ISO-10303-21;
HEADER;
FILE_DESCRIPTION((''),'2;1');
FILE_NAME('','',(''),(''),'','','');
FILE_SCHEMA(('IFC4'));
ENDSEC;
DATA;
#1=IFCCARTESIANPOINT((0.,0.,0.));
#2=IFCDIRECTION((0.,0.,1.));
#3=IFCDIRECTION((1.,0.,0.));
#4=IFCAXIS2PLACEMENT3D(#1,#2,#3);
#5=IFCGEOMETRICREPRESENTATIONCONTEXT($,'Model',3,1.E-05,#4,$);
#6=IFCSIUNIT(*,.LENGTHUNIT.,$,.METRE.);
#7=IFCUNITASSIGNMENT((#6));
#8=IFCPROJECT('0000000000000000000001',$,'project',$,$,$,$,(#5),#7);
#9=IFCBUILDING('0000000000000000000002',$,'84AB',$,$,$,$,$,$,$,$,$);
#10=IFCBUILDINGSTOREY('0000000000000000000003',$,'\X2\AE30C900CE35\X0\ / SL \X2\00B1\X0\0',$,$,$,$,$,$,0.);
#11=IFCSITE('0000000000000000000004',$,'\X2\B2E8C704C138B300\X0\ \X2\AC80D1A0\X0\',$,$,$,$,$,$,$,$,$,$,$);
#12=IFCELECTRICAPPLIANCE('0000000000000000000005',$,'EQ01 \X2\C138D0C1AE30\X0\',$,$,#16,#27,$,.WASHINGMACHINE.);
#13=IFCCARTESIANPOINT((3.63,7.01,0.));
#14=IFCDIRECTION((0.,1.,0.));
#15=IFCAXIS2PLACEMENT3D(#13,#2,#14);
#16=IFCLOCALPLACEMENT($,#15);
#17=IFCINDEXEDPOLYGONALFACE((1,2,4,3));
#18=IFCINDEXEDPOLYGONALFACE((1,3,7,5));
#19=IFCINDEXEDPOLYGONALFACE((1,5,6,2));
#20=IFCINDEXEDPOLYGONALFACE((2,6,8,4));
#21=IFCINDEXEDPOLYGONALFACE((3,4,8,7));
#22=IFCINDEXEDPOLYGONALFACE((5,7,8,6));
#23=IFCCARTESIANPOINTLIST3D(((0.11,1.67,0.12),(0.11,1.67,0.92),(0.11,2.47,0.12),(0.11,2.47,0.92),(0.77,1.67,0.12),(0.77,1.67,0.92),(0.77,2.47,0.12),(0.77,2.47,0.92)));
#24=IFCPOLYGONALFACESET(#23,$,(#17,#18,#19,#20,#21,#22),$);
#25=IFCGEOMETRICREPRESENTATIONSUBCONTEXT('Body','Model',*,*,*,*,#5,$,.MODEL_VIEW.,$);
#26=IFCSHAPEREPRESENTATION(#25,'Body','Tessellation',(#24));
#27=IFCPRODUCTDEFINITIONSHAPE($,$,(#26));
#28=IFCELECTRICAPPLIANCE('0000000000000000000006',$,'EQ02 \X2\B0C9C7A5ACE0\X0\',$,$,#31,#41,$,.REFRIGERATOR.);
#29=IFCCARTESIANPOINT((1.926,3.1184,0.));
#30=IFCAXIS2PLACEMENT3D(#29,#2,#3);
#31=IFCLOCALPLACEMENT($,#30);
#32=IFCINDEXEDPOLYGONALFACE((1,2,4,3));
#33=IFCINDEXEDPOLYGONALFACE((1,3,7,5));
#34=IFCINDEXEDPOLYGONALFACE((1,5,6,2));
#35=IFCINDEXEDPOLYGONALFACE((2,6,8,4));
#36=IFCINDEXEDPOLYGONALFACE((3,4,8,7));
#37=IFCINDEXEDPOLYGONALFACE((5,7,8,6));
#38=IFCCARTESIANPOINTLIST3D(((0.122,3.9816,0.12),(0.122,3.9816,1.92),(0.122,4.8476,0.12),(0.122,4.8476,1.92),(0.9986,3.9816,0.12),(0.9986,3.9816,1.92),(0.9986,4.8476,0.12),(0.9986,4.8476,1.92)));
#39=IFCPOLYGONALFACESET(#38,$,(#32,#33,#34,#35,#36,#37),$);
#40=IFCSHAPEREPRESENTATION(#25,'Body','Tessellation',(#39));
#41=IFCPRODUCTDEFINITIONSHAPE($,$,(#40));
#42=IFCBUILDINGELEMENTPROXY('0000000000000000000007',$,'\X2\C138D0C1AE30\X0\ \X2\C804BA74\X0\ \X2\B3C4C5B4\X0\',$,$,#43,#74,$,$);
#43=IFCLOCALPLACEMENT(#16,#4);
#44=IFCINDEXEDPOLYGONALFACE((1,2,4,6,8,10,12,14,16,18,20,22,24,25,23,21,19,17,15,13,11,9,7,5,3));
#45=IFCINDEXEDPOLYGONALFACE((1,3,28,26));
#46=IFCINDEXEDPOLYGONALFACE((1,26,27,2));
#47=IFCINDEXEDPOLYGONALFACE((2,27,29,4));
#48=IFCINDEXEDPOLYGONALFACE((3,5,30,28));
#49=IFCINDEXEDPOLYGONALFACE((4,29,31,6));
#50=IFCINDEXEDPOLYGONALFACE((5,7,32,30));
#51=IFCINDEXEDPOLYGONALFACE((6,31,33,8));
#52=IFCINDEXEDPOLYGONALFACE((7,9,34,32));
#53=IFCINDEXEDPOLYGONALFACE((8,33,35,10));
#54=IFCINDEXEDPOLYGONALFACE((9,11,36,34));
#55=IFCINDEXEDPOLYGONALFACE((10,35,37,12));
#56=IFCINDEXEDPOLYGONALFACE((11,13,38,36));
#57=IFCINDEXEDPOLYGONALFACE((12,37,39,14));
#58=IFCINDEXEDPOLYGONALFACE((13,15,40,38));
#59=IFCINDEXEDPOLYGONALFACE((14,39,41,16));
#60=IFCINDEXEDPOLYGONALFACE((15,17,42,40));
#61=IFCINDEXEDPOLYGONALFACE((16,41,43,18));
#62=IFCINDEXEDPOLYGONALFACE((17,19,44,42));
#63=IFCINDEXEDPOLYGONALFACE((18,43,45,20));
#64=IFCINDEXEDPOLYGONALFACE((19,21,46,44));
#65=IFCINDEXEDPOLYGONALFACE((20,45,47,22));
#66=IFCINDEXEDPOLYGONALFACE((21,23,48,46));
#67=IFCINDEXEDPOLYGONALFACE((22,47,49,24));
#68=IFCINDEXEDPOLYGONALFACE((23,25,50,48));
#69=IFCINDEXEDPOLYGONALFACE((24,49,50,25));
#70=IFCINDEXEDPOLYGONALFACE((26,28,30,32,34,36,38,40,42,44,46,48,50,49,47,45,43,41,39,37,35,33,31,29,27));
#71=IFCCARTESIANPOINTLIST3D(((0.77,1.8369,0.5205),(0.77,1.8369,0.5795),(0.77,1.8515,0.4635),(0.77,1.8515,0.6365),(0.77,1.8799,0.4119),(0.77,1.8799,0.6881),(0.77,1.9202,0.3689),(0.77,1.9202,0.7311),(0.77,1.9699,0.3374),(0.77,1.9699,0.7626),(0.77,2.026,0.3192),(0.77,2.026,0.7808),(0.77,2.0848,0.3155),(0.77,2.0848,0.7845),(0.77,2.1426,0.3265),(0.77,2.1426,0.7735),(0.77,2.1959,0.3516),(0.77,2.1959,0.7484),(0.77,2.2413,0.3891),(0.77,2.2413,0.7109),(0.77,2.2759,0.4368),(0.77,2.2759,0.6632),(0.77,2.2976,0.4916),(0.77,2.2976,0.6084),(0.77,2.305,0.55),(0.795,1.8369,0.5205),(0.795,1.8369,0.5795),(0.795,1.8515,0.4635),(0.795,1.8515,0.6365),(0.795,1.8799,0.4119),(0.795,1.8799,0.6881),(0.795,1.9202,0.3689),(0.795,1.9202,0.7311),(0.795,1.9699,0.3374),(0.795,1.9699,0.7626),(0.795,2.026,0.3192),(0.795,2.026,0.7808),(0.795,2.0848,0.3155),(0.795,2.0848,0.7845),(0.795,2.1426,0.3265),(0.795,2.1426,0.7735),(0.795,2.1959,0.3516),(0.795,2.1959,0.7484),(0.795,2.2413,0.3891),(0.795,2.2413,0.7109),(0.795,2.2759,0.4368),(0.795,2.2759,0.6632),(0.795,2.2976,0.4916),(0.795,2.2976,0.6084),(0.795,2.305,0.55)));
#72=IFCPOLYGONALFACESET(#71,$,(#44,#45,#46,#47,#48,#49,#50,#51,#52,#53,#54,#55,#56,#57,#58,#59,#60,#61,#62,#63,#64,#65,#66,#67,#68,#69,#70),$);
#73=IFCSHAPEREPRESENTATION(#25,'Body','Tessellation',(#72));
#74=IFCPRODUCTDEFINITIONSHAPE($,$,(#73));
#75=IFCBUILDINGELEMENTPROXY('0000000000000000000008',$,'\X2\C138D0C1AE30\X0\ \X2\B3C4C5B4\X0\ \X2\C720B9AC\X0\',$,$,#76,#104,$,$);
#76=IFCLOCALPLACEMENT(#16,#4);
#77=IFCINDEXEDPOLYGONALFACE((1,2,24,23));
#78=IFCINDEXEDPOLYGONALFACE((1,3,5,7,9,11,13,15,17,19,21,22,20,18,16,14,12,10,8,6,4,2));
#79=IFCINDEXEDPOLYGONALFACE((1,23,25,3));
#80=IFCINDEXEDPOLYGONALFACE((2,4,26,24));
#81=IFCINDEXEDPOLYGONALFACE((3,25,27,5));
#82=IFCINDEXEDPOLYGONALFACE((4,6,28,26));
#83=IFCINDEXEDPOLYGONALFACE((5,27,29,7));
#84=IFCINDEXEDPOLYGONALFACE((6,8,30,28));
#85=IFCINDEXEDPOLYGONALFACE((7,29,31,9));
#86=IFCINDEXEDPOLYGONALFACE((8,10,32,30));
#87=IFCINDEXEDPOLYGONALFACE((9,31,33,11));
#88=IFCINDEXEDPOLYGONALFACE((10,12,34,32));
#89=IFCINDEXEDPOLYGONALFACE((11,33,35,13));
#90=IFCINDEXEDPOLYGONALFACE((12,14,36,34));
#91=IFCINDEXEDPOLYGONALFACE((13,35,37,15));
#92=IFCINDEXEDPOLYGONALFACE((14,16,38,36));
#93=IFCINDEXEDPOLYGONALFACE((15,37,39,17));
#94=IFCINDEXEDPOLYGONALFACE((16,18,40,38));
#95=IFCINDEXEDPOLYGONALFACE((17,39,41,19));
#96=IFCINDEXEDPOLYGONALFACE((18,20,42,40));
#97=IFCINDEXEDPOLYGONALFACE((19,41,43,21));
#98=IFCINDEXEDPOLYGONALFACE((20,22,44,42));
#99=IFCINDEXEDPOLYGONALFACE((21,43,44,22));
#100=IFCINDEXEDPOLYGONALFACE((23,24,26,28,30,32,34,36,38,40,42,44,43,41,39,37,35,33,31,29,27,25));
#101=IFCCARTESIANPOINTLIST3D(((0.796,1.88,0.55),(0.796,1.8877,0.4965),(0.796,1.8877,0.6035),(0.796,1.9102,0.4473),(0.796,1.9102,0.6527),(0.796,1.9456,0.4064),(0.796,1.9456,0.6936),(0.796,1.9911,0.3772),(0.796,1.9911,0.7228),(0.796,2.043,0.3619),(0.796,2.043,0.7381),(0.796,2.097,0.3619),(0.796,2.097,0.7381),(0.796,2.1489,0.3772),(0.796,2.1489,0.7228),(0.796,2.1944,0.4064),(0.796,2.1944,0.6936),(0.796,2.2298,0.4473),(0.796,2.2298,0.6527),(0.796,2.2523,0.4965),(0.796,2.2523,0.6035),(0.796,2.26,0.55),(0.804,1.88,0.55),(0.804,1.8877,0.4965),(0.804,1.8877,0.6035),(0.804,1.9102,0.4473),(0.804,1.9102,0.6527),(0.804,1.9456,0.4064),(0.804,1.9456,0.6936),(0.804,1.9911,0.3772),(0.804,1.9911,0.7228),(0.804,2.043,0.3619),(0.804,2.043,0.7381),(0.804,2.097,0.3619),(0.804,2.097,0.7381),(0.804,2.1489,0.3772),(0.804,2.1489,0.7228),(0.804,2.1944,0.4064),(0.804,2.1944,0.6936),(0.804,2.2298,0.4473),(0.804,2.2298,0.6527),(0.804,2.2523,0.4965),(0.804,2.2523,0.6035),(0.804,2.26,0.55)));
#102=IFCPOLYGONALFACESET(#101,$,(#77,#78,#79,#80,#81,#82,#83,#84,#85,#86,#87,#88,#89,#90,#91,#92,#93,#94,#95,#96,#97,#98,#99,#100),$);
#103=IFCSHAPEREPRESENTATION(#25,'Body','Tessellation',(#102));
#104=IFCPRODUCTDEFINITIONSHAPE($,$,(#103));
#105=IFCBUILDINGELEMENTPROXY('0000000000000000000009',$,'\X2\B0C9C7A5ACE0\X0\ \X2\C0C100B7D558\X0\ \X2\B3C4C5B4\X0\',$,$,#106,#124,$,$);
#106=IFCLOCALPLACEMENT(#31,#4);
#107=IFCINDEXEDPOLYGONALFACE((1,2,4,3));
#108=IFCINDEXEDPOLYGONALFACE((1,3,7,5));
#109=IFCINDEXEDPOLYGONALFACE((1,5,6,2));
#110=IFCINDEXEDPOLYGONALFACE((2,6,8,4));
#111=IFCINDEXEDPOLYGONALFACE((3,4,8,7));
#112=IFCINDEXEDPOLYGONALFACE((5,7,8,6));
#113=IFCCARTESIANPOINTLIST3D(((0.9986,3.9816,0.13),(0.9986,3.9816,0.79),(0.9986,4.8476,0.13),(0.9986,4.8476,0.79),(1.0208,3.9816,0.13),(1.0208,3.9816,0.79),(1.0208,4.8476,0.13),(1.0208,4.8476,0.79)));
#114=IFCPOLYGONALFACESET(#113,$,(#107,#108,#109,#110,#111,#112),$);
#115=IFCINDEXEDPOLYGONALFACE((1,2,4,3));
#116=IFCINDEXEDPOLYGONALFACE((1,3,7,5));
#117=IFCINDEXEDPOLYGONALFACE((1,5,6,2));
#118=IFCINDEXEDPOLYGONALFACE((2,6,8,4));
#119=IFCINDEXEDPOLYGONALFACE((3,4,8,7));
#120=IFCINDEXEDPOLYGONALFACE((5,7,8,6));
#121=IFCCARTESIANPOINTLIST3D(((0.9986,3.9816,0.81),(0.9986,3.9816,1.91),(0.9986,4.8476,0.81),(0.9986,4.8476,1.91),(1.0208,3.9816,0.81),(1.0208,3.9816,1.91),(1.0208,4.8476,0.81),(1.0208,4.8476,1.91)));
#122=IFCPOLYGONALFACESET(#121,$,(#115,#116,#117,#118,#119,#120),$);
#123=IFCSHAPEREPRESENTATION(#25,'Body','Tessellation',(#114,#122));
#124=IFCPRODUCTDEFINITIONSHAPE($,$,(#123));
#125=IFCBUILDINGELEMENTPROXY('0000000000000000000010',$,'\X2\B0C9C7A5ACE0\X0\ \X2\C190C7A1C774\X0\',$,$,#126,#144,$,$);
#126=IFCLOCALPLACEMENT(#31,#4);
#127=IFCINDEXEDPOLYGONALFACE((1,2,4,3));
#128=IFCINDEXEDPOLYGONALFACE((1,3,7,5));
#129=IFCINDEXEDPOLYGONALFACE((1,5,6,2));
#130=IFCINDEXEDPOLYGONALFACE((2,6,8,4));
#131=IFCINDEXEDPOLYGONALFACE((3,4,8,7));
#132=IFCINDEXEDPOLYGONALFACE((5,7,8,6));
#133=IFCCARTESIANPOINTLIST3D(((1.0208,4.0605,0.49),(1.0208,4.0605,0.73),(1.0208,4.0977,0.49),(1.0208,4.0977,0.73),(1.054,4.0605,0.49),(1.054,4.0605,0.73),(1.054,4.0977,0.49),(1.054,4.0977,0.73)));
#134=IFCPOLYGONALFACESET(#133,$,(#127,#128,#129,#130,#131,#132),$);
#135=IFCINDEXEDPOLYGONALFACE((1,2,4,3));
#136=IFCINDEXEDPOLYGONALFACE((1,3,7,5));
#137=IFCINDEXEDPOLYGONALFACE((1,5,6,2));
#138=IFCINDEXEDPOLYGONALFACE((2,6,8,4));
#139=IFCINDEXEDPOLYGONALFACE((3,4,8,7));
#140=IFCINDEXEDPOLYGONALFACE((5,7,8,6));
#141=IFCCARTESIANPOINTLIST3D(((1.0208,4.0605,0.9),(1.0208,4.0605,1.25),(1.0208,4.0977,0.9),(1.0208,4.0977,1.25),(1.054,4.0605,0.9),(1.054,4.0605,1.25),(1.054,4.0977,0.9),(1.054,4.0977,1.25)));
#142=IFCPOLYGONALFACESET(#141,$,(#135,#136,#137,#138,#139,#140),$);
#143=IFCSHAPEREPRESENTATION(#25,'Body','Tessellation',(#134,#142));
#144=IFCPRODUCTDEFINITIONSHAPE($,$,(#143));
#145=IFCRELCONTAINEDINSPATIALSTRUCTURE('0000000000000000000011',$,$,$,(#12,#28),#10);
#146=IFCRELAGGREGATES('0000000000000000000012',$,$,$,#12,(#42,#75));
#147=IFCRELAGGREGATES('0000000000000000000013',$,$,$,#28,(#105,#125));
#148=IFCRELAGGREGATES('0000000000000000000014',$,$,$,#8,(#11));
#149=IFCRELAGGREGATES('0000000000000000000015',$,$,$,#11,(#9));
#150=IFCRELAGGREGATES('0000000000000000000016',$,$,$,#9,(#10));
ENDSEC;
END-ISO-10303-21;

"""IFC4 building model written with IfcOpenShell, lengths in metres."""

from ifc_helpers import new_model, si_unit, frame, origin_with_axes, place, context, subcontext, project, spatial, polyline, circle, outline, extrude, element, aggregate, save


model = new_model("IFC4")

# Units and contexts
model_context = context("Model", 3, precision=1e-05, world=origin_with_axes())
body_context = subcontext(model_context, "Body", "Model", "MODEL_VIEW")
ifc_project = project(units=[si_unit("LENGTHUNIT", "METRE")], contexts=[model_context])

# Site, building, storey
site = spatial("IfcSite", under=ifc_project, Name="단위세대 검토")
building = spatial("IfcBuilding", under=site, Name="84AB")
storey = spatial("IfcBuildingStorey", under=building, Name="기준층 / SL ±0", Elevation=0.0)

# Electric appliances
electric_appliance_1_placement = place(None, frame((3.63, 7.01, 0.0), z_axis=(0.0, 0.0, 1.0), x_axis=(0.0, 1.0, 0.0)))
electric_appliance_1 = element("IfcElectricAppliance", 1, at=electric_appliance_1_placement, inside=storey, Name="EQ01 세탁기", PredefinedType="WASHINGMACHINE", context=body_context, shape_type="SweptSolid", body=[
    extrude(outline(polyline([(0.77, 1.67), (0.77, 2.47), (0.11, 2.47), (0.11, 1.67), (0.77, 1.67)])), frame((0.0, 0.0, 0.12)), (0.0, 0.0, 1.0), 0.8),
])
electric_appliance_2_placement = place(None, frame((1.926, 3.1184, 0.0), z_axis=(0.0, 0.0, 1.0), x_axis=(1.0, 0.0, 0.0)))
electric_appliance_2 = element("IfcElectricAppliance", 2, at=electric_appliance_2_placement, inside=storey, Name="EQ02 냉장고", PredefinedType="REFRIGERATOR", context=body_context, shape_type="SweptSolid", body=[
    extrude(outline(polyline([(0.9986, 3.9816), (0.9986, 4.8476), (0.122, 4.8476), (0.122, 3.9816), (0.9986, 3.9816)])), frame((0.0, 0.0, 0.12)), (0.0, 0.0, 1.0), 1.8),
])

# Building element proxies
proxy_1_placement = place(electric_appliance_1_placement, origin_with_axes())
proxy_1 = element("IfcBuildingElementProxy", 3, at=proxy_1_placement, Name="세탁기 전면 도어", context=body_context, shape_type="SweptSolid", body=[
    extrude(circle(Radius=0.235), frame((0.77, 2.07, 0.55), z_axis=(1.0, 0.0, 0.0), x_axis=(0.0, 1.0, 0.0)), (0.0, 0.0, 1.0), 0.025),
])
proxy_2_placement = place(electric_appliance_1_placement, origin_with_axes())
proxy_2 = element("IfcBuildingElementProxy", 4, at=proxy_2_placement, Name="세탁기 도어 유리", context=body_context, shape_type="SweptSolid", body=[
    extrude(circle(Radius=0.19), frame((0.796, 2.07, 0.55), z_axis=(1.0, 0.0, 0.0), x_axis=(0.0, 1.0, 0.0)), (0.0, 0.0, 1.0), 0.008),
])
aggregate(electric_appliance_1, [proxy_1, proxy_2])
proxy_3_placement = place(electric_appliance_2_placement, origin_with_axes())
proxy_3 = element("IfcBuildingElementProxy", 5, at=proxy_3_placement, Name="냉장고 상·하 도어", context=body_context, shape_type="SweptSolid", body=[
    extrude(outline(polyline([(1.0208, 3.9816), (1.0208, 4.8476), (0.9986, 4.8476), (0.9986, 3.9816), (1.0208, 3.9816)])), frame((0.0, 0.0, 0.13)), (0.0, 0.0, 1.0), 0.66),
    extrude(outline(polyline([(1.0208, 3.9816), (1.0208, 4.8476), (0.9986, 4.8476), (0.9986, 3.9816), (1.0208, 3.9816)])), frame((0.0, 0.0, 0.81)), (0.0, 0.0, 1.0), 1.1),
])
proxy_4_placement = place(electric_appliance_2_placement, origin_with_axes())
proxy_4 = element("IfcBuildingElementProxy", 6, at=proxy_4_placement, Name="냉장고 손잡이", context=body_context, shape_type="SweptSolid", body=[
    extrude(outline(polyline([(1.054, 4.0605), (1.054, 4.0977), (1.0208, 4.0977), (1.0208, 4.0605), (1.054, 4.0605)])), frame((0.0, 0.0, 0.49)), (0.0, 0.0, 1.0), 0.24),
    extrude(outline(polyline([(1.054, 4.0605), (1.054, 4.0977), (1.0208, 4.0977), (1.0208, 4.0605), (1.054, 4.0605)])), frame((0.0, 0.0, 0.9)), (0.0, 0.0, 1.0), 0.35),
])
aggregate(electric_appliance_2, [proxy_3, proxy_4])

save(model, "model.ifc")
